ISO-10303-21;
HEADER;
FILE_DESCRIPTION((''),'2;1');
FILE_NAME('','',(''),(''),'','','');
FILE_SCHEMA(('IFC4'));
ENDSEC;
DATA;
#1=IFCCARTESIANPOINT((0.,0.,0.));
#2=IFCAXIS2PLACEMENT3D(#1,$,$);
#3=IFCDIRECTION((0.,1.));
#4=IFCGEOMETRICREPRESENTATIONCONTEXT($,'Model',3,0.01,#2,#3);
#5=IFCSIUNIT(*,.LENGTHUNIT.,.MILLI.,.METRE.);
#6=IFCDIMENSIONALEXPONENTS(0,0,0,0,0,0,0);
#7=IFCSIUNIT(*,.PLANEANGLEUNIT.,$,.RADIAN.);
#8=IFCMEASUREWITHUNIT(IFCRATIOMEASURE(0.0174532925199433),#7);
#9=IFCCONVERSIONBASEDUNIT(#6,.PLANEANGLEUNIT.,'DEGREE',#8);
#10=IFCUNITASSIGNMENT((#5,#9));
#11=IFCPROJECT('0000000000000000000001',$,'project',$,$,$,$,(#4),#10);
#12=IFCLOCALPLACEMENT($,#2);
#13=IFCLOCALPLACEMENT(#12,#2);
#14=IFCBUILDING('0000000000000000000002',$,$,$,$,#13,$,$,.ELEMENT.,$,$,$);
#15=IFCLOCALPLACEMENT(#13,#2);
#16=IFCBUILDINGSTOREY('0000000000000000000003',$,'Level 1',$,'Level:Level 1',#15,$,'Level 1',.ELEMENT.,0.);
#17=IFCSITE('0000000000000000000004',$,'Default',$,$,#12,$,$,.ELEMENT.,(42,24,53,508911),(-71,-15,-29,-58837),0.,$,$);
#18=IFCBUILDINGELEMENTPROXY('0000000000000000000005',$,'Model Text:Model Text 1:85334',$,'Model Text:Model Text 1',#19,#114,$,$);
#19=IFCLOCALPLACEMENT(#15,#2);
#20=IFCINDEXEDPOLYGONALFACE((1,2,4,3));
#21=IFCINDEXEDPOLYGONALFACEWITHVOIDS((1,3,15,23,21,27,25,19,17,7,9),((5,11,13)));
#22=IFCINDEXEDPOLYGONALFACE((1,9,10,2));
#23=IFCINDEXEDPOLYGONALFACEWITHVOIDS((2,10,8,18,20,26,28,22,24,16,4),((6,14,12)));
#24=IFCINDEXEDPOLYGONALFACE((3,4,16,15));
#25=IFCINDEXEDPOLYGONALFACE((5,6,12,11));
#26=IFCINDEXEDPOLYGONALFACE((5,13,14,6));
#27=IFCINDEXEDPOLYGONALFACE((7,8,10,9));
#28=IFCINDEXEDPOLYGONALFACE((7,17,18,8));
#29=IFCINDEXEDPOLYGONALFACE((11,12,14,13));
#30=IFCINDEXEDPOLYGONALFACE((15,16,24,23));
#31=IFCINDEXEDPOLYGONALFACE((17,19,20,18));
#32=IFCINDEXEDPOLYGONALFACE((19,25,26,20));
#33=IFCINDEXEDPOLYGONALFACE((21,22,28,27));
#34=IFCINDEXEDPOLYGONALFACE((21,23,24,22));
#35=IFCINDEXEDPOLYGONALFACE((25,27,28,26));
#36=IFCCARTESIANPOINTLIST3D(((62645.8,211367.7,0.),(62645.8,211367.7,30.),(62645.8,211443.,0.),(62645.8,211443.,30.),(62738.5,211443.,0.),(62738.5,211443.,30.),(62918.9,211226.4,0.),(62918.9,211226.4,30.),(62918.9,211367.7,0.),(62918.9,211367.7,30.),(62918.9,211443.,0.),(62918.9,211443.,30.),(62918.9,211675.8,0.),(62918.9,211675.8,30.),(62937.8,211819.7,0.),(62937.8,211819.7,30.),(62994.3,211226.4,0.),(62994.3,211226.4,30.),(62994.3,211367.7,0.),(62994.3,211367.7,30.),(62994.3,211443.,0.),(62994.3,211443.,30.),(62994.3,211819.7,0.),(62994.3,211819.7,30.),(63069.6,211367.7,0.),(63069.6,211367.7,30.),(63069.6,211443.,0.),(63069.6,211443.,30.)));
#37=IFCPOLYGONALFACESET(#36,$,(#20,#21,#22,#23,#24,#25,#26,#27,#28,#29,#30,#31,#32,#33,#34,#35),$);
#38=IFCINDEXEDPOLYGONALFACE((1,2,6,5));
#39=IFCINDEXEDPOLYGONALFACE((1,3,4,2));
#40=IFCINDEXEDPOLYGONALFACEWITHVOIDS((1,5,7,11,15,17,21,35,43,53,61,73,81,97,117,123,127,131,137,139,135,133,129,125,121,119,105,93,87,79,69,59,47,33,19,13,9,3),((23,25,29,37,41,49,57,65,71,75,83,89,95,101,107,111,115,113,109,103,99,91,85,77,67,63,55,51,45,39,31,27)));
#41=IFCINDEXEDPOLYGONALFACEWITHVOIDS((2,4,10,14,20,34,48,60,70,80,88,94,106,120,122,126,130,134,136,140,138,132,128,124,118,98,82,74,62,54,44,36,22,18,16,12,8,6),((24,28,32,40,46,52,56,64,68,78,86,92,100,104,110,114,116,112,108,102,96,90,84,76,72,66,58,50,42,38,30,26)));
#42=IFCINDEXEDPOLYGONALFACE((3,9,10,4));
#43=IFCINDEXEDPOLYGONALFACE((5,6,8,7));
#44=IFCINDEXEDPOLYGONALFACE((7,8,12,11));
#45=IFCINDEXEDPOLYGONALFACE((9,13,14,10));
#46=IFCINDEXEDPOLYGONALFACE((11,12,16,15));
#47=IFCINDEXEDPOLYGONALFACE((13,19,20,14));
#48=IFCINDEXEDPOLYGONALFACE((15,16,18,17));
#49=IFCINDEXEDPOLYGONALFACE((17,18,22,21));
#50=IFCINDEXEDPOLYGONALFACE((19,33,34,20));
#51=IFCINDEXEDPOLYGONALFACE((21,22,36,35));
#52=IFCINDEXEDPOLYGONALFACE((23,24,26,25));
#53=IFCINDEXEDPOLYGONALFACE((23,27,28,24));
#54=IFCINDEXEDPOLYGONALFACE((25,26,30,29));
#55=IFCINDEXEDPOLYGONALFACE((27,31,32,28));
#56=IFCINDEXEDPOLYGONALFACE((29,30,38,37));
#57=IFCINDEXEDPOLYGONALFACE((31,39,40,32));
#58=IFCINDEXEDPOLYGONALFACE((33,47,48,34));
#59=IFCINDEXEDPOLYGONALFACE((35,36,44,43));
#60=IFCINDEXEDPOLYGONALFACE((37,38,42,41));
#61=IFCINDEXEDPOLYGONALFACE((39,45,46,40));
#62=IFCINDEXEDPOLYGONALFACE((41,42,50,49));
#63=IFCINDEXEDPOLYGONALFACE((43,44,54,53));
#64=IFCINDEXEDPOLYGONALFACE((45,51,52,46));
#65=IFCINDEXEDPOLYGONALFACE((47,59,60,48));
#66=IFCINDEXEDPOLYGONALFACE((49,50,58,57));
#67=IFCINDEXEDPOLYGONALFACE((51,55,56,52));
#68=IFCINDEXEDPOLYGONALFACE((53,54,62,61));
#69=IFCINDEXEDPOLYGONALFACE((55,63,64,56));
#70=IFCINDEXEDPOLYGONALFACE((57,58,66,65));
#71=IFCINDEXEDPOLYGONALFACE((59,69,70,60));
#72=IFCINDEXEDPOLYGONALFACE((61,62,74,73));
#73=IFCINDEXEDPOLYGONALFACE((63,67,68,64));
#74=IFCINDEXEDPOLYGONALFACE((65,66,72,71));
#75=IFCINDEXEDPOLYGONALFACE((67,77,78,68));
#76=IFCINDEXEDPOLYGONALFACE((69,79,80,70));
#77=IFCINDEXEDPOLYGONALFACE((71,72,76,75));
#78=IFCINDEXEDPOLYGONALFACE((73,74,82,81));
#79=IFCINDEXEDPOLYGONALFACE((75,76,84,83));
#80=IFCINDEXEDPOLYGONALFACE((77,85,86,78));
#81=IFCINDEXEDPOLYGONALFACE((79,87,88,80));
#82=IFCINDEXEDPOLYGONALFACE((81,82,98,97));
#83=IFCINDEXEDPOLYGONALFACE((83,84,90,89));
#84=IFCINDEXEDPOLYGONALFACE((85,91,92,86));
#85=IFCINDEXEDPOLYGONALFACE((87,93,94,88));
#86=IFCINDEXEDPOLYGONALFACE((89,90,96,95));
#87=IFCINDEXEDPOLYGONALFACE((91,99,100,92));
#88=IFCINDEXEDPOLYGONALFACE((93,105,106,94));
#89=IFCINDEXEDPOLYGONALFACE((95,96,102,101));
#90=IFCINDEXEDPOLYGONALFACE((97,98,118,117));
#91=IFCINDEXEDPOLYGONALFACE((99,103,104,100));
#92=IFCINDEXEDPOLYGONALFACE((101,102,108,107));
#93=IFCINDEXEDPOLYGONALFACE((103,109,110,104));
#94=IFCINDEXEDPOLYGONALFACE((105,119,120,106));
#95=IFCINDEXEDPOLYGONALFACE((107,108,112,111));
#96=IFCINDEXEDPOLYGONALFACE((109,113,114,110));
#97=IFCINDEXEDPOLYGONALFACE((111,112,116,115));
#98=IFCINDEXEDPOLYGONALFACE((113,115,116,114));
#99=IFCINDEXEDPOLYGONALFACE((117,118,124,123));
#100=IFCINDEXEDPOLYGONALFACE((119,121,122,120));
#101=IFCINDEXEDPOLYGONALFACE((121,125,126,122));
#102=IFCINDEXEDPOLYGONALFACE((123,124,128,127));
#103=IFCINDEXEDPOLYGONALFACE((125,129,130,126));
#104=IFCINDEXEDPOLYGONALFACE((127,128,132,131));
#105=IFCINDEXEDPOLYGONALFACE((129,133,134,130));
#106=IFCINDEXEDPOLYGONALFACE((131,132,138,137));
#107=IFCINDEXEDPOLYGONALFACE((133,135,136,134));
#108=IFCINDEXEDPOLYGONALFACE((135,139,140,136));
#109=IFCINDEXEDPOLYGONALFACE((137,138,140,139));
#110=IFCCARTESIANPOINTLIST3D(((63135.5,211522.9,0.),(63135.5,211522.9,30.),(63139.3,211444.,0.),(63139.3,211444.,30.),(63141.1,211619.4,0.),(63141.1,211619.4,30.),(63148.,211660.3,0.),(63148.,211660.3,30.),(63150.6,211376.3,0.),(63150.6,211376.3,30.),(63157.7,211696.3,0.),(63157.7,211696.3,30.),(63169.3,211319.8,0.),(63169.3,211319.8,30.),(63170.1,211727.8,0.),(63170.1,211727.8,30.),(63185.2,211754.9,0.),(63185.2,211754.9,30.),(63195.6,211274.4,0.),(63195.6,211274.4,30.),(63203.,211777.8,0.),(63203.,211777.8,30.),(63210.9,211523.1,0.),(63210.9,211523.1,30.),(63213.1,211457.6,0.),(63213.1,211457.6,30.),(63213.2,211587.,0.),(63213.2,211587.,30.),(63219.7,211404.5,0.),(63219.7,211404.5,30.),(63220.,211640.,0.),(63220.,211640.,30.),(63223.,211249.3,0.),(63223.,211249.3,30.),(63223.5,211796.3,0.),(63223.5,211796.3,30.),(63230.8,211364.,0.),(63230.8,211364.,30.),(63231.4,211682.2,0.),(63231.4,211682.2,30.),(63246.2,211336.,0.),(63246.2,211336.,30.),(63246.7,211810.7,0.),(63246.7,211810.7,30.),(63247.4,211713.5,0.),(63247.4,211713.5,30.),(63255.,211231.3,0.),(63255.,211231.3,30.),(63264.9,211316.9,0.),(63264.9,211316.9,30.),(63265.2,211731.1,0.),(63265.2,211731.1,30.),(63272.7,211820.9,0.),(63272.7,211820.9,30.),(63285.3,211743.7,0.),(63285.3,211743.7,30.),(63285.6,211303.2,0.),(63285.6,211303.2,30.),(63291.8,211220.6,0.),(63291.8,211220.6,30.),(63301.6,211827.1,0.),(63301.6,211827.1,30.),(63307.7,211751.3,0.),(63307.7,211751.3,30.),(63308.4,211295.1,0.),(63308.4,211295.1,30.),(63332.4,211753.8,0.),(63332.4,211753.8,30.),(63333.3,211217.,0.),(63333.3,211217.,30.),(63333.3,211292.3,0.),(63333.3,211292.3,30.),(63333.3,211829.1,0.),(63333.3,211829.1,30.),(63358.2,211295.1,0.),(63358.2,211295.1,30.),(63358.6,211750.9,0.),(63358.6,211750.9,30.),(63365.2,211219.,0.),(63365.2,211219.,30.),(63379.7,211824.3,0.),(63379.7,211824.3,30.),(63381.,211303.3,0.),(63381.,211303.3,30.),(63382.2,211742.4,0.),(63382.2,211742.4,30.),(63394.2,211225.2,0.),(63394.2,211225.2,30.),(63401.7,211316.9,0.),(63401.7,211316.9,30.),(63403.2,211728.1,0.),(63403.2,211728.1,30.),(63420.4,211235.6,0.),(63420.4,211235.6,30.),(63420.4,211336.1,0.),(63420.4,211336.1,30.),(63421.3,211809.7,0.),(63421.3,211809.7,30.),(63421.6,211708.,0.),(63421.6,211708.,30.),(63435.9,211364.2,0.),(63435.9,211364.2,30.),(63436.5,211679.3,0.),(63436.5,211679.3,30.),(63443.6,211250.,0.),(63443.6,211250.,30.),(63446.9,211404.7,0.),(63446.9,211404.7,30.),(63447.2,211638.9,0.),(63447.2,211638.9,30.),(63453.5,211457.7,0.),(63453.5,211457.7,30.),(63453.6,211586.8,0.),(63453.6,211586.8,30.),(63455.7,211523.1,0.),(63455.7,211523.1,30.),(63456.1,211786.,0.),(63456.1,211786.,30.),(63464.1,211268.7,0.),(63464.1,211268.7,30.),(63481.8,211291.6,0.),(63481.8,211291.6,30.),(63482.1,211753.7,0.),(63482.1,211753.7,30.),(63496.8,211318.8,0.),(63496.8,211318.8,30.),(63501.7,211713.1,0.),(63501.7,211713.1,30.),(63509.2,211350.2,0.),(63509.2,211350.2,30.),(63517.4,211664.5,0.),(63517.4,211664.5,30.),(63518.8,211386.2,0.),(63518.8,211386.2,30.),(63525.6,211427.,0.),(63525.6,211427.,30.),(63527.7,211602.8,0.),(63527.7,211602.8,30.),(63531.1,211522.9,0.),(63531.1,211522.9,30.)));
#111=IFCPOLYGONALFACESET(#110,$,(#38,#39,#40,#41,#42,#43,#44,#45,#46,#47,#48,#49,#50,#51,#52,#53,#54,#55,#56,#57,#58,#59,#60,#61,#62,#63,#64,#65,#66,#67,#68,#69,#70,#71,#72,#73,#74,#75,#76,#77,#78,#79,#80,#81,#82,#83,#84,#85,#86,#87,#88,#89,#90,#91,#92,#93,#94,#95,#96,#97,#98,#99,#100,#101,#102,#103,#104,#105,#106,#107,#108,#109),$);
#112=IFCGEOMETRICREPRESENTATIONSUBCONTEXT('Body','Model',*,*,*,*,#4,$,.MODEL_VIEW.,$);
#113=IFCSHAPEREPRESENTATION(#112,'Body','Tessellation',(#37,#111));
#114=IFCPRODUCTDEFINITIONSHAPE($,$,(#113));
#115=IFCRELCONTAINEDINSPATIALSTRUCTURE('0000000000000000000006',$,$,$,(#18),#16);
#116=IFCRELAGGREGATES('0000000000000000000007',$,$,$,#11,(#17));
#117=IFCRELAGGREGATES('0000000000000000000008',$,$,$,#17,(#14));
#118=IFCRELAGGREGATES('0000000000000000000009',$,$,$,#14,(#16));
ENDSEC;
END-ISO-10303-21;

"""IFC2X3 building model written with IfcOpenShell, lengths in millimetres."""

from ifc_helpers import new_model, entity, si_unit, converted_unit, direction, frame, origin, place, context, subcontext, project, spatial, polyline, outline, extrude, element, save


model = new_model("IFC2X3")

# Units and contexts
model_context = context("Model", 3, precision=0.01, world=origin(), true_north=direction((0.0, 1.0)))
body_context = subcontext(model_context, "Body", "Model", "MODEL_VIEW")
ifc_project = project(units=[si_unit("LENGTHUNIT", "METRE", prefix="MILLI"), converted_unit("PLANEANGLEUNIT", "DEGREE", entity("IfcRatioMeasure", 0.0174532925199433), si_unit("PLANEANGLEUNIT", "RADIAN"), dimensions=[0, 0, 0, 0, 0, 0, 0])], contexts=[model_context])

# Site, building, storey
site_placement = place(None, origin())
site = spatial("IfcSite", under=ifc_project, at=site_placement, Name="Default", CompositionType="ELEMENT", RefLatitude=(42, 24, 53, 508911), RefLongitude=(-71, -15, -29, -58837), RefElevation=0.0)
building_placement = place(site_placement, origin())
building = spatial("IfcBuilding", under=site, at=building_placement, CompositionType="ELEMENT")
storey_placement = place(building_placement, origin())
storey = spatial("IfcBuildingStorey", under=building, at=storey_placement, Name="Level 1", ObjectType="Level:Level 1", LongName="Level 1", CompositionType="ELEMENT", Elevation=0.0)

# Building element proxy
proxy_1_placement = place(storey_placement, origin())
element("IfcBuildingElementProxy", 1, at=proxy_1_placement, inside=storey, Name="Model Text:Model Text 1:85334", ObjectType="Model Text:Model Text 1", context=body_context, shape_type="SweptSolid", body=[
    extrude(outline(polyline([(-6.8, -218.3), (68.5, -218.3), (68.5, -77.1), (143.8, -77.1), (143.8, -1.7), (68.5, -1.7), (68.5, 375.0), (12.0, 375.0), (-280.0, -1.7), (-280.0, -77.1), (-6.8, -77.1), (-6.8, -218.3)]), holes=[polyline([(-6.8, -1.7), (-187.3, -1.7), (-6.8, 231.1), (-6.8, -1.7)])]), frame((62925.8, 211444.7, 0.0)), (0.0, 0.0, 1.0), 30.0),
    extrude(outline(polyline([(-10.6, -198.7), (68.3, -198.7), (136.5, -190.7), (193.9, -174.7), (240.5, -150.6), (266.9, -124.4), (286.3, -93.2), (298.8, -57.0), (304.3, -15.7), (303.8, 16.2), (299.0, 45.5), (289.9, 72.1), (276.6, 96.0), (258.9, 117.3), (236.9, 136.2), (210.4, 152.5), (179.6, 166.3), (144.1, 177.6), (103.7, 186.3), (8.2, 196.4), (-71.8, 196.7), (-134.0, 189.4), (-183.3, 176.1), (-224.7, 158.4), (-258.2, 133.9), (-283.5, 100.3), (-300.1, 59.5), (-307.1, 13.4), (-306.6, -18.4), (-301.8, -47.5), (-292.8, -74.0), (-279.6, -97.9), (-262.0, -119.2), (-240.0, -138.1), (-213.6, -154.5), (-182.8, -168.4), (-147.3, -179.8), (-106.7, -188.6), (-10.6, -198.7)]), holes=[polyline([(-7.2, -123.5), (-71.0, -118.2), (-123.6, -108.8), (-165.2, -95.4), (-195.7, -78.0), (-212.4, -59.4), (-224.1, -38.7), (-230.6, -15.9), (-231.9, 8.9), (-227.8, 35.0), (-218.1, 58.1), (-202.8, 78.4), (-182.0, 95.8), (-152.6, 109.4), (-111.7, 118.1), (-59.4, 122.0), (4.4, 121.1), (69.6, 115.8), (122.2, 106.7), (162.2, 93.7), (189.5, 77.0), (207.7, 57.4), (220.4, 36.0), (227.5, 12.8), (229.1, -12.1), (225.2, -36.8), (215.9, -59.2), (201.3, -79.3), (181.4, -97.1), (152.6, -111.2), (111.6, -120.3), (58.3, -124.4), (-7.2, -123.5)])]), frame((63334.6, 211521.7, 0.0), z_axis=(0.0, 0.0, 1.0), x_axis=(0.047515, -0.998871, 0.0)), (0.0, 0.0, 1.0), 30.0),
])

save(model, "model.ifc")
